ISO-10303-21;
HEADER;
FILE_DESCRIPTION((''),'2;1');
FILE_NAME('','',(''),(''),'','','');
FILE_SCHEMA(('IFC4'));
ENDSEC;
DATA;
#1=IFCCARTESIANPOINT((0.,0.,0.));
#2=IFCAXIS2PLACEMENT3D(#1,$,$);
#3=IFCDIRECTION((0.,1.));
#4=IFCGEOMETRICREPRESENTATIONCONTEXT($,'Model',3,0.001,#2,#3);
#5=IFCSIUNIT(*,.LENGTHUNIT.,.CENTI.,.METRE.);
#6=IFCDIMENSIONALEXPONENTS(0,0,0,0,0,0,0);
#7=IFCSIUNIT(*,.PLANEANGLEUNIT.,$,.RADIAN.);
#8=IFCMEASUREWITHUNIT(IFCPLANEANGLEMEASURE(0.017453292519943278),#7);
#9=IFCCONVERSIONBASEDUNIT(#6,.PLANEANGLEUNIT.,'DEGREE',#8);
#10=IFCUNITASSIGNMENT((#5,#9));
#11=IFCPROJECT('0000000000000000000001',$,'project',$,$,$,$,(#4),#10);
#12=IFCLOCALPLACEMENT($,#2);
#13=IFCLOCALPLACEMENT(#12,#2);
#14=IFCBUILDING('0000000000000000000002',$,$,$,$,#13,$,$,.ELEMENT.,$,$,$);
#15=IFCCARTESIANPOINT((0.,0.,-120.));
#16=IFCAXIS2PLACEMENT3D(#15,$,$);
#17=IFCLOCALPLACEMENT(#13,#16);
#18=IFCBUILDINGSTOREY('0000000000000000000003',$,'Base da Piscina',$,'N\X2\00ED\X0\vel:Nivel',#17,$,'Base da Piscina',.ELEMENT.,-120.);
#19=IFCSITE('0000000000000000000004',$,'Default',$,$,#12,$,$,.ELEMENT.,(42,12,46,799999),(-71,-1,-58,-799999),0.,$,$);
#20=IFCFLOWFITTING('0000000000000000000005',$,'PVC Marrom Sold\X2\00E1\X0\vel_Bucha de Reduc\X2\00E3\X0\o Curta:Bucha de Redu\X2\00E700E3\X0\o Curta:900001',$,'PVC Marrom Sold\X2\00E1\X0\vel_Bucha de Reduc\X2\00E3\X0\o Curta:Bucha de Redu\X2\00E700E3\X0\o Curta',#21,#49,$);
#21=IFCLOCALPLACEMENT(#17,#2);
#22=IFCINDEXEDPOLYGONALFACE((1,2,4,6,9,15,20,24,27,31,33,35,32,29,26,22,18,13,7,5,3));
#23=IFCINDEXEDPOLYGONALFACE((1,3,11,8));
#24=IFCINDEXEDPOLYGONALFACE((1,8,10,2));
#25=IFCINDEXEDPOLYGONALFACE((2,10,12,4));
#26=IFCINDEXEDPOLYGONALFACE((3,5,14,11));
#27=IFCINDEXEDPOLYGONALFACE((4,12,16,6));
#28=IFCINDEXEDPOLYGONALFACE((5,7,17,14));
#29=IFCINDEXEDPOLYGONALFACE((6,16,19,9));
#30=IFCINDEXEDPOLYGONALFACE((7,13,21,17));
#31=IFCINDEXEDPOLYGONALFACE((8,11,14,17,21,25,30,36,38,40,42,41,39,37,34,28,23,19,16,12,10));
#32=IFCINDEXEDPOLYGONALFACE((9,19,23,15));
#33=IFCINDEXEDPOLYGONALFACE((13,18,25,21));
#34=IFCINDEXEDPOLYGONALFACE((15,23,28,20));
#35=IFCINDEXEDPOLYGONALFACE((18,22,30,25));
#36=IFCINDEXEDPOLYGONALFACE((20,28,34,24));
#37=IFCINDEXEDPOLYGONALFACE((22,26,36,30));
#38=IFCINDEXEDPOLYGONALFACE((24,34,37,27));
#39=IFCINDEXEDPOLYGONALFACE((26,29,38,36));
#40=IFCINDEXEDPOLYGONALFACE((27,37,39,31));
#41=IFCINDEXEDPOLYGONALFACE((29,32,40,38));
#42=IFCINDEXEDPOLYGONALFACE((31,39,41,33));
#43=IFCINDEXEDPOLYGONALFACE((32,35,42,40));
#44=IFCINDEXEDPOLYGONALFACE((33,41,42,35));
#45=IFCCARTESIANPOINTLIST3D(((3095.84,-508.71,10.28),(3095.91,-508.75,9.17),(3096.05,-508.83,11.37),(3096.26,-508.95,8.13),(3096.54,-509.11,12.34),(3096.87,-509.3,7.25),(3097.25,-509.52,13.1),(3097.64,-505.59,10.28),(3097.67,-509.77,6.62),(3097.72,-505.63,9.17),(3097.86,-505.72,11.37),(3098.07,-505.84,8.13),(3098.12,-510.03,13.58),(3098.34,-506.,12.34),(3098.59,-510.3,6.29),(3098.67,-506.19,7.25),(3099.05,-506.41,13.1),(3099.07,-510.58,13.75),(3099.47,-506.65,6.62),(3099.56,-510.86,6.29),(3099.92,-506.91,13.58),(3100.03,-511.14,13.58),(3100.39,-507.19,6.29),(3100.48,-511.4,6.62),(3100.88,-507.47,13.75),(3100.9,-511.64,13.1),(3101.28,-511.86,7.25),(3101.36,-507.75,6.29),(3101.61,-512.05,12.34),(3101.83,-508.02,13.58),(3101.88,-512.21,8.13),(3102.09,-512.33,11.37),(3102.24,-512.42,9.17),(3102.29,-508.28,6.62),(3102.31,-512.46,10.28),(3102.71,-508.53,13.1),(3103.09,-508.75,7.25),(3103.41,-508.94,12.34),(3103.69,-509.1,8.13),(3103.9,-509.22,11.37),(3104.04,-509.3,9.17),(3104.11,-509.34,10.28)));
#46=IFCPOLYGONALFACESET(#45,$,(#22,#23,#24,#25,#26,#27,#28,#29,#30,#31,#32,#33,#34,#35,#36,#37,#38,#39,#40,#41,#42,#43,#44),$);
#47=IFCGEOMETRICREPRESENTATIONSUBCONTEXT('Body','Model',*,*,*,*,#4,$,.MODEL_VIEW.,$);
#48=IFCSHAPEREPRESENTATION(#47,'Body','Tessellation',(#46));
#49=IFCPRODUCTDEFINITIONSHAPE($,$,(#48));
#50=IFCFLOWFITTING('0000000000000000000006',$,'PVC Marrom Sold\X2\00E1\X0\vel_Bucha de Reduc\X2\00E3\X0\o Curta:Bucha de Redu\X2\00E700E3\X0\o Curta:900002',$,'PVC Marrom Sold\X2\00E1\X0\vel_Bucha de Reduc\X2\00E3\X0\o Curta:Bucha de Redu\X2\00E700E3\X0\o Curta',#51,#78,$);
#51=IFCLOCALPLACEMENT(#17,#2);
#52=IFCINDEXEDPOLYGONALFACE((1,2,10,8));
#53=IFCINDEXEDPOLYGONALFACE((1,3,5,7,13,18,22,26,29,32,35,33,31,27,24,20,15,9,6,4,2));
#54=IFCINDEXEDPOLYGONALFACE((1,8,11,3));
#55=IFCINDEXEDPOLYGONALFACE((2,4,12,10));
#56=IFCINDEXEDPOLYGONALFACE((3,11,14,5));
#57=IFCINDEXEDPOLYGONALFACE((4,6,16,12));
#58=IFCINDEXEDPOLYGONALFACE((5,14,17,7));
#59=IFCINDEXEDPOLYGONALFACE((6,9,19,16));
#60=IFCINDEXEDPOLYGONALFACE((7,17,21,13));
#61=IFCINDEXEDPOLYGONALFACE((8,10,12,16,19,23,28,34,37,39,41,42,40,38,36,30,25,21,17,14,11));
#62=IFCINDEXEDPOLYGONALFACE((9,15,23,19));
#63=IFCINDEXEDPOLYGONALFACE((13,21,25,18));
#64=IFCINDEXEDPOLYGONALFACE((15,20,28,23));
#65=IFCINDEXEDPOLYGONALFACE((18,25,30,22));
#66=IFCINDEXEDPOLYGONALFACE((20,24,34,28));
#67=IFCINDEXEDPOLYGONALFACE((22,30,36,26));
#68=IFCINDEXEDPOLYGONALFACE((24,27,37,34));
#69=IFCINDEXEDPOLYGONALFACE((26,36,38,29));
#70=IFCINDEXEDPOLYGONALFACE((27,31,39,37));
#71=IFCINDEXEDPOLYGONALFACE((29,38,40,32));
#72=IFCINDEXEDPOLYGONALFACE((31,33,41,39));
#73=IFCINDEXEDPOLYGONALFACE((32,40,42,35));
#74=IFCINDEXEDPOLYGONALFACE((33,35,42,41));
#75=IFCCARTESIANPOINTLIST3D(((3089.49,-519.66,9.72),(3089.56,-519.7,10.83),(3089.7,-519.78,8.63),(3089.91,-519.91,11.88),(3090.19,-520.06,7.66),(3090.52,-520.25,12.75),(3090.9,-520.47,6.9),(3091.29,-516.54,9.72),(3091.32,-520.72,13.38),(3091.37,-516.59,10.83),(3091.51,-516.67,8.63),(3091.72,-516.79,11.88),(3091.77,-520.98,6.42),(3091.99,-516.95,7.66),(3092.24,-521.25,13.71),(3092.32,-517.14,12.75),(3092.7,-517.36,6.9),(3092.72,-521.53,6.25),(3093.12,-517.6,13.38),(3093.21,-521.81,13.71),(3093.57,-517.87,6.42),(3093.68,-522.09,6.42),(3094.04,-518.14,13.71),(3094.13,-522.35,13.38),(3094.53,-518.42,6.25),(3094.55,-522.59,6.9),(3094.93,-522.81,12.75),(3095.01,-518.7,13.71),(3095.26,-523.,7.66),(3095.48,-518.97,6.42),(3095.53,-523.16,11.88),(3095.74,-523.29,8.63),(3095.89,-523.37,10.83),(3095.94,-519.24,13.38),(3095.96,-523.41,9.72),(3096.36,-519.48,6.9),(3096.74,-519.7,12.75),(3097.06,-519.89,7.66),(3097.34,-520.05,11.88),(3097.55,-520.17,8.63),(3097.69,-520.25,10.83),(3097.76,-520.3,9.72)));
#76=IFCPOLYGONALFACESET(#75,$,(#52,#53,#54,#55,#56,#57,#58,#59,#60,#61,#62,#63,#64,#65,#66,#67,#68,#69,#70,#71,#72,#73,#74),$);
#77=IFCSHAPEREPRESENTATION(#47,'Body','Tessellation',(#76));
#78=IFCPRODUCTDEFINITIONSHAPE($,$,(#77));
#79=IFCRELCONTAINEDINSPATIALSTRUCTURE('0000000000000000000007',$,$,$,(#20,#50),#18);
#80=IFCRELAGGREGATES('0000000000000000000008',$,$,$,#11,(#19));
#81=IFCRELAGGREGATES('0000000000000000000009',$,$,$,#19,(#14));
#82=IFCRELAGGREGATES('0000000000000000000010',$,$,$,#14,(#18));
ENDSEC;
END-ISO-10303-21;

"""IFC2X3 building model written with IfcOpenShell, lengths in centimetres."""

from ifc_helpers import new_model, entity, si_unit, converted_unit, direction, frame, origin, origin_2d, place, context, subcontext, project, spatial, circle, extrude, element, save


model = new_model("IFC2X3")

# Units and contexts
model_context = context("Model", 3, precision=0.001, world=origin(), true_north=direction((0.0, 1.0)))
body_context = subcontext(model_context, "Body", "Model", "MODEL_VIEW")
ifc_project = project(units=[si_unit("LENGTHUNIT", "METRE", prefix="CENTI"), converted_unit("PLANEANGLEUNIT", "DEGREE", entity("IfcPlaneAngleMeasure", 0.017453292519943278), si_unit("PLANEANGLEUNIT", "RADIAN"), dimensions=[0, 0, 0, 0, 0, 0, 0])], contexts=[model_context])

# Site, building, storey
site_placement = place(None, origin())
site = spatial("IfcSite", under=ifc_project, at=site_placement, Name="Default", CompositionType="ELEMENT", RefLatitude=(42, 12, 46, 799999), RefLongitude=(-71, -1, -58, -799999), RefElevation=0.0)
building_placement = place(site_placement, origin())
building = spatial("IfcBuilding", under=site, at=building_placement, CompositionType="ELEMENT")
storey_placement = place(building_placement, frame((0.0, 0.0, -120.0)))
storey = spatial("IfcBuildingStorey", under=building, at=storey_placement, Name="Base da Piscina", ObjectType="Nível:Nivel", LongName="Base da Piscina", CompositionType="ELEMENT", Elevation=-120.0)

# Flow fittings
placement = place(storey_placement, frame((3096.8, -514.5, 10.0), z_axis=(0.865569, -0.50079, 0.0), x_axis=(-0.50079, -0.865569, 0.0)))
for number, where, z_axis, x_axis, name in (
    (1, (-4.53, 0.0, 0.0), (-1.0, 0.0, 0.000913), (0.0, -1.0, 0.0), "PVC Marrom Soldável_Bucha de Reducão Curta:Bucha de Redução Curta:900001"),
    (2, (4.53, 0.0, 0.0), (1.0, 0.0, -0.000913), (0.0, 1.0, 0.0), "PVC Marrom Soldável_Bucha de Reducão Curta:Bucha de Redução Curta:900002"),
):
    element("IfcFlowFitting", number, at=place(placement, frame(where, z_axis=z_axis, x_axis=x_axis)), inside=storey, Name=name, ObjectType="PVC Marrom Soldável_Bucha de Reducão Curta:Bucha de Redução Curta", context=body_context, shape_type="SweptSolid", body=[
        extrude(circle(Radius=3.75, at=origin_2d()), origin(), (0.0, 0.0, 1.0), 3.6),
    ])

save(model, "model.ifc")
